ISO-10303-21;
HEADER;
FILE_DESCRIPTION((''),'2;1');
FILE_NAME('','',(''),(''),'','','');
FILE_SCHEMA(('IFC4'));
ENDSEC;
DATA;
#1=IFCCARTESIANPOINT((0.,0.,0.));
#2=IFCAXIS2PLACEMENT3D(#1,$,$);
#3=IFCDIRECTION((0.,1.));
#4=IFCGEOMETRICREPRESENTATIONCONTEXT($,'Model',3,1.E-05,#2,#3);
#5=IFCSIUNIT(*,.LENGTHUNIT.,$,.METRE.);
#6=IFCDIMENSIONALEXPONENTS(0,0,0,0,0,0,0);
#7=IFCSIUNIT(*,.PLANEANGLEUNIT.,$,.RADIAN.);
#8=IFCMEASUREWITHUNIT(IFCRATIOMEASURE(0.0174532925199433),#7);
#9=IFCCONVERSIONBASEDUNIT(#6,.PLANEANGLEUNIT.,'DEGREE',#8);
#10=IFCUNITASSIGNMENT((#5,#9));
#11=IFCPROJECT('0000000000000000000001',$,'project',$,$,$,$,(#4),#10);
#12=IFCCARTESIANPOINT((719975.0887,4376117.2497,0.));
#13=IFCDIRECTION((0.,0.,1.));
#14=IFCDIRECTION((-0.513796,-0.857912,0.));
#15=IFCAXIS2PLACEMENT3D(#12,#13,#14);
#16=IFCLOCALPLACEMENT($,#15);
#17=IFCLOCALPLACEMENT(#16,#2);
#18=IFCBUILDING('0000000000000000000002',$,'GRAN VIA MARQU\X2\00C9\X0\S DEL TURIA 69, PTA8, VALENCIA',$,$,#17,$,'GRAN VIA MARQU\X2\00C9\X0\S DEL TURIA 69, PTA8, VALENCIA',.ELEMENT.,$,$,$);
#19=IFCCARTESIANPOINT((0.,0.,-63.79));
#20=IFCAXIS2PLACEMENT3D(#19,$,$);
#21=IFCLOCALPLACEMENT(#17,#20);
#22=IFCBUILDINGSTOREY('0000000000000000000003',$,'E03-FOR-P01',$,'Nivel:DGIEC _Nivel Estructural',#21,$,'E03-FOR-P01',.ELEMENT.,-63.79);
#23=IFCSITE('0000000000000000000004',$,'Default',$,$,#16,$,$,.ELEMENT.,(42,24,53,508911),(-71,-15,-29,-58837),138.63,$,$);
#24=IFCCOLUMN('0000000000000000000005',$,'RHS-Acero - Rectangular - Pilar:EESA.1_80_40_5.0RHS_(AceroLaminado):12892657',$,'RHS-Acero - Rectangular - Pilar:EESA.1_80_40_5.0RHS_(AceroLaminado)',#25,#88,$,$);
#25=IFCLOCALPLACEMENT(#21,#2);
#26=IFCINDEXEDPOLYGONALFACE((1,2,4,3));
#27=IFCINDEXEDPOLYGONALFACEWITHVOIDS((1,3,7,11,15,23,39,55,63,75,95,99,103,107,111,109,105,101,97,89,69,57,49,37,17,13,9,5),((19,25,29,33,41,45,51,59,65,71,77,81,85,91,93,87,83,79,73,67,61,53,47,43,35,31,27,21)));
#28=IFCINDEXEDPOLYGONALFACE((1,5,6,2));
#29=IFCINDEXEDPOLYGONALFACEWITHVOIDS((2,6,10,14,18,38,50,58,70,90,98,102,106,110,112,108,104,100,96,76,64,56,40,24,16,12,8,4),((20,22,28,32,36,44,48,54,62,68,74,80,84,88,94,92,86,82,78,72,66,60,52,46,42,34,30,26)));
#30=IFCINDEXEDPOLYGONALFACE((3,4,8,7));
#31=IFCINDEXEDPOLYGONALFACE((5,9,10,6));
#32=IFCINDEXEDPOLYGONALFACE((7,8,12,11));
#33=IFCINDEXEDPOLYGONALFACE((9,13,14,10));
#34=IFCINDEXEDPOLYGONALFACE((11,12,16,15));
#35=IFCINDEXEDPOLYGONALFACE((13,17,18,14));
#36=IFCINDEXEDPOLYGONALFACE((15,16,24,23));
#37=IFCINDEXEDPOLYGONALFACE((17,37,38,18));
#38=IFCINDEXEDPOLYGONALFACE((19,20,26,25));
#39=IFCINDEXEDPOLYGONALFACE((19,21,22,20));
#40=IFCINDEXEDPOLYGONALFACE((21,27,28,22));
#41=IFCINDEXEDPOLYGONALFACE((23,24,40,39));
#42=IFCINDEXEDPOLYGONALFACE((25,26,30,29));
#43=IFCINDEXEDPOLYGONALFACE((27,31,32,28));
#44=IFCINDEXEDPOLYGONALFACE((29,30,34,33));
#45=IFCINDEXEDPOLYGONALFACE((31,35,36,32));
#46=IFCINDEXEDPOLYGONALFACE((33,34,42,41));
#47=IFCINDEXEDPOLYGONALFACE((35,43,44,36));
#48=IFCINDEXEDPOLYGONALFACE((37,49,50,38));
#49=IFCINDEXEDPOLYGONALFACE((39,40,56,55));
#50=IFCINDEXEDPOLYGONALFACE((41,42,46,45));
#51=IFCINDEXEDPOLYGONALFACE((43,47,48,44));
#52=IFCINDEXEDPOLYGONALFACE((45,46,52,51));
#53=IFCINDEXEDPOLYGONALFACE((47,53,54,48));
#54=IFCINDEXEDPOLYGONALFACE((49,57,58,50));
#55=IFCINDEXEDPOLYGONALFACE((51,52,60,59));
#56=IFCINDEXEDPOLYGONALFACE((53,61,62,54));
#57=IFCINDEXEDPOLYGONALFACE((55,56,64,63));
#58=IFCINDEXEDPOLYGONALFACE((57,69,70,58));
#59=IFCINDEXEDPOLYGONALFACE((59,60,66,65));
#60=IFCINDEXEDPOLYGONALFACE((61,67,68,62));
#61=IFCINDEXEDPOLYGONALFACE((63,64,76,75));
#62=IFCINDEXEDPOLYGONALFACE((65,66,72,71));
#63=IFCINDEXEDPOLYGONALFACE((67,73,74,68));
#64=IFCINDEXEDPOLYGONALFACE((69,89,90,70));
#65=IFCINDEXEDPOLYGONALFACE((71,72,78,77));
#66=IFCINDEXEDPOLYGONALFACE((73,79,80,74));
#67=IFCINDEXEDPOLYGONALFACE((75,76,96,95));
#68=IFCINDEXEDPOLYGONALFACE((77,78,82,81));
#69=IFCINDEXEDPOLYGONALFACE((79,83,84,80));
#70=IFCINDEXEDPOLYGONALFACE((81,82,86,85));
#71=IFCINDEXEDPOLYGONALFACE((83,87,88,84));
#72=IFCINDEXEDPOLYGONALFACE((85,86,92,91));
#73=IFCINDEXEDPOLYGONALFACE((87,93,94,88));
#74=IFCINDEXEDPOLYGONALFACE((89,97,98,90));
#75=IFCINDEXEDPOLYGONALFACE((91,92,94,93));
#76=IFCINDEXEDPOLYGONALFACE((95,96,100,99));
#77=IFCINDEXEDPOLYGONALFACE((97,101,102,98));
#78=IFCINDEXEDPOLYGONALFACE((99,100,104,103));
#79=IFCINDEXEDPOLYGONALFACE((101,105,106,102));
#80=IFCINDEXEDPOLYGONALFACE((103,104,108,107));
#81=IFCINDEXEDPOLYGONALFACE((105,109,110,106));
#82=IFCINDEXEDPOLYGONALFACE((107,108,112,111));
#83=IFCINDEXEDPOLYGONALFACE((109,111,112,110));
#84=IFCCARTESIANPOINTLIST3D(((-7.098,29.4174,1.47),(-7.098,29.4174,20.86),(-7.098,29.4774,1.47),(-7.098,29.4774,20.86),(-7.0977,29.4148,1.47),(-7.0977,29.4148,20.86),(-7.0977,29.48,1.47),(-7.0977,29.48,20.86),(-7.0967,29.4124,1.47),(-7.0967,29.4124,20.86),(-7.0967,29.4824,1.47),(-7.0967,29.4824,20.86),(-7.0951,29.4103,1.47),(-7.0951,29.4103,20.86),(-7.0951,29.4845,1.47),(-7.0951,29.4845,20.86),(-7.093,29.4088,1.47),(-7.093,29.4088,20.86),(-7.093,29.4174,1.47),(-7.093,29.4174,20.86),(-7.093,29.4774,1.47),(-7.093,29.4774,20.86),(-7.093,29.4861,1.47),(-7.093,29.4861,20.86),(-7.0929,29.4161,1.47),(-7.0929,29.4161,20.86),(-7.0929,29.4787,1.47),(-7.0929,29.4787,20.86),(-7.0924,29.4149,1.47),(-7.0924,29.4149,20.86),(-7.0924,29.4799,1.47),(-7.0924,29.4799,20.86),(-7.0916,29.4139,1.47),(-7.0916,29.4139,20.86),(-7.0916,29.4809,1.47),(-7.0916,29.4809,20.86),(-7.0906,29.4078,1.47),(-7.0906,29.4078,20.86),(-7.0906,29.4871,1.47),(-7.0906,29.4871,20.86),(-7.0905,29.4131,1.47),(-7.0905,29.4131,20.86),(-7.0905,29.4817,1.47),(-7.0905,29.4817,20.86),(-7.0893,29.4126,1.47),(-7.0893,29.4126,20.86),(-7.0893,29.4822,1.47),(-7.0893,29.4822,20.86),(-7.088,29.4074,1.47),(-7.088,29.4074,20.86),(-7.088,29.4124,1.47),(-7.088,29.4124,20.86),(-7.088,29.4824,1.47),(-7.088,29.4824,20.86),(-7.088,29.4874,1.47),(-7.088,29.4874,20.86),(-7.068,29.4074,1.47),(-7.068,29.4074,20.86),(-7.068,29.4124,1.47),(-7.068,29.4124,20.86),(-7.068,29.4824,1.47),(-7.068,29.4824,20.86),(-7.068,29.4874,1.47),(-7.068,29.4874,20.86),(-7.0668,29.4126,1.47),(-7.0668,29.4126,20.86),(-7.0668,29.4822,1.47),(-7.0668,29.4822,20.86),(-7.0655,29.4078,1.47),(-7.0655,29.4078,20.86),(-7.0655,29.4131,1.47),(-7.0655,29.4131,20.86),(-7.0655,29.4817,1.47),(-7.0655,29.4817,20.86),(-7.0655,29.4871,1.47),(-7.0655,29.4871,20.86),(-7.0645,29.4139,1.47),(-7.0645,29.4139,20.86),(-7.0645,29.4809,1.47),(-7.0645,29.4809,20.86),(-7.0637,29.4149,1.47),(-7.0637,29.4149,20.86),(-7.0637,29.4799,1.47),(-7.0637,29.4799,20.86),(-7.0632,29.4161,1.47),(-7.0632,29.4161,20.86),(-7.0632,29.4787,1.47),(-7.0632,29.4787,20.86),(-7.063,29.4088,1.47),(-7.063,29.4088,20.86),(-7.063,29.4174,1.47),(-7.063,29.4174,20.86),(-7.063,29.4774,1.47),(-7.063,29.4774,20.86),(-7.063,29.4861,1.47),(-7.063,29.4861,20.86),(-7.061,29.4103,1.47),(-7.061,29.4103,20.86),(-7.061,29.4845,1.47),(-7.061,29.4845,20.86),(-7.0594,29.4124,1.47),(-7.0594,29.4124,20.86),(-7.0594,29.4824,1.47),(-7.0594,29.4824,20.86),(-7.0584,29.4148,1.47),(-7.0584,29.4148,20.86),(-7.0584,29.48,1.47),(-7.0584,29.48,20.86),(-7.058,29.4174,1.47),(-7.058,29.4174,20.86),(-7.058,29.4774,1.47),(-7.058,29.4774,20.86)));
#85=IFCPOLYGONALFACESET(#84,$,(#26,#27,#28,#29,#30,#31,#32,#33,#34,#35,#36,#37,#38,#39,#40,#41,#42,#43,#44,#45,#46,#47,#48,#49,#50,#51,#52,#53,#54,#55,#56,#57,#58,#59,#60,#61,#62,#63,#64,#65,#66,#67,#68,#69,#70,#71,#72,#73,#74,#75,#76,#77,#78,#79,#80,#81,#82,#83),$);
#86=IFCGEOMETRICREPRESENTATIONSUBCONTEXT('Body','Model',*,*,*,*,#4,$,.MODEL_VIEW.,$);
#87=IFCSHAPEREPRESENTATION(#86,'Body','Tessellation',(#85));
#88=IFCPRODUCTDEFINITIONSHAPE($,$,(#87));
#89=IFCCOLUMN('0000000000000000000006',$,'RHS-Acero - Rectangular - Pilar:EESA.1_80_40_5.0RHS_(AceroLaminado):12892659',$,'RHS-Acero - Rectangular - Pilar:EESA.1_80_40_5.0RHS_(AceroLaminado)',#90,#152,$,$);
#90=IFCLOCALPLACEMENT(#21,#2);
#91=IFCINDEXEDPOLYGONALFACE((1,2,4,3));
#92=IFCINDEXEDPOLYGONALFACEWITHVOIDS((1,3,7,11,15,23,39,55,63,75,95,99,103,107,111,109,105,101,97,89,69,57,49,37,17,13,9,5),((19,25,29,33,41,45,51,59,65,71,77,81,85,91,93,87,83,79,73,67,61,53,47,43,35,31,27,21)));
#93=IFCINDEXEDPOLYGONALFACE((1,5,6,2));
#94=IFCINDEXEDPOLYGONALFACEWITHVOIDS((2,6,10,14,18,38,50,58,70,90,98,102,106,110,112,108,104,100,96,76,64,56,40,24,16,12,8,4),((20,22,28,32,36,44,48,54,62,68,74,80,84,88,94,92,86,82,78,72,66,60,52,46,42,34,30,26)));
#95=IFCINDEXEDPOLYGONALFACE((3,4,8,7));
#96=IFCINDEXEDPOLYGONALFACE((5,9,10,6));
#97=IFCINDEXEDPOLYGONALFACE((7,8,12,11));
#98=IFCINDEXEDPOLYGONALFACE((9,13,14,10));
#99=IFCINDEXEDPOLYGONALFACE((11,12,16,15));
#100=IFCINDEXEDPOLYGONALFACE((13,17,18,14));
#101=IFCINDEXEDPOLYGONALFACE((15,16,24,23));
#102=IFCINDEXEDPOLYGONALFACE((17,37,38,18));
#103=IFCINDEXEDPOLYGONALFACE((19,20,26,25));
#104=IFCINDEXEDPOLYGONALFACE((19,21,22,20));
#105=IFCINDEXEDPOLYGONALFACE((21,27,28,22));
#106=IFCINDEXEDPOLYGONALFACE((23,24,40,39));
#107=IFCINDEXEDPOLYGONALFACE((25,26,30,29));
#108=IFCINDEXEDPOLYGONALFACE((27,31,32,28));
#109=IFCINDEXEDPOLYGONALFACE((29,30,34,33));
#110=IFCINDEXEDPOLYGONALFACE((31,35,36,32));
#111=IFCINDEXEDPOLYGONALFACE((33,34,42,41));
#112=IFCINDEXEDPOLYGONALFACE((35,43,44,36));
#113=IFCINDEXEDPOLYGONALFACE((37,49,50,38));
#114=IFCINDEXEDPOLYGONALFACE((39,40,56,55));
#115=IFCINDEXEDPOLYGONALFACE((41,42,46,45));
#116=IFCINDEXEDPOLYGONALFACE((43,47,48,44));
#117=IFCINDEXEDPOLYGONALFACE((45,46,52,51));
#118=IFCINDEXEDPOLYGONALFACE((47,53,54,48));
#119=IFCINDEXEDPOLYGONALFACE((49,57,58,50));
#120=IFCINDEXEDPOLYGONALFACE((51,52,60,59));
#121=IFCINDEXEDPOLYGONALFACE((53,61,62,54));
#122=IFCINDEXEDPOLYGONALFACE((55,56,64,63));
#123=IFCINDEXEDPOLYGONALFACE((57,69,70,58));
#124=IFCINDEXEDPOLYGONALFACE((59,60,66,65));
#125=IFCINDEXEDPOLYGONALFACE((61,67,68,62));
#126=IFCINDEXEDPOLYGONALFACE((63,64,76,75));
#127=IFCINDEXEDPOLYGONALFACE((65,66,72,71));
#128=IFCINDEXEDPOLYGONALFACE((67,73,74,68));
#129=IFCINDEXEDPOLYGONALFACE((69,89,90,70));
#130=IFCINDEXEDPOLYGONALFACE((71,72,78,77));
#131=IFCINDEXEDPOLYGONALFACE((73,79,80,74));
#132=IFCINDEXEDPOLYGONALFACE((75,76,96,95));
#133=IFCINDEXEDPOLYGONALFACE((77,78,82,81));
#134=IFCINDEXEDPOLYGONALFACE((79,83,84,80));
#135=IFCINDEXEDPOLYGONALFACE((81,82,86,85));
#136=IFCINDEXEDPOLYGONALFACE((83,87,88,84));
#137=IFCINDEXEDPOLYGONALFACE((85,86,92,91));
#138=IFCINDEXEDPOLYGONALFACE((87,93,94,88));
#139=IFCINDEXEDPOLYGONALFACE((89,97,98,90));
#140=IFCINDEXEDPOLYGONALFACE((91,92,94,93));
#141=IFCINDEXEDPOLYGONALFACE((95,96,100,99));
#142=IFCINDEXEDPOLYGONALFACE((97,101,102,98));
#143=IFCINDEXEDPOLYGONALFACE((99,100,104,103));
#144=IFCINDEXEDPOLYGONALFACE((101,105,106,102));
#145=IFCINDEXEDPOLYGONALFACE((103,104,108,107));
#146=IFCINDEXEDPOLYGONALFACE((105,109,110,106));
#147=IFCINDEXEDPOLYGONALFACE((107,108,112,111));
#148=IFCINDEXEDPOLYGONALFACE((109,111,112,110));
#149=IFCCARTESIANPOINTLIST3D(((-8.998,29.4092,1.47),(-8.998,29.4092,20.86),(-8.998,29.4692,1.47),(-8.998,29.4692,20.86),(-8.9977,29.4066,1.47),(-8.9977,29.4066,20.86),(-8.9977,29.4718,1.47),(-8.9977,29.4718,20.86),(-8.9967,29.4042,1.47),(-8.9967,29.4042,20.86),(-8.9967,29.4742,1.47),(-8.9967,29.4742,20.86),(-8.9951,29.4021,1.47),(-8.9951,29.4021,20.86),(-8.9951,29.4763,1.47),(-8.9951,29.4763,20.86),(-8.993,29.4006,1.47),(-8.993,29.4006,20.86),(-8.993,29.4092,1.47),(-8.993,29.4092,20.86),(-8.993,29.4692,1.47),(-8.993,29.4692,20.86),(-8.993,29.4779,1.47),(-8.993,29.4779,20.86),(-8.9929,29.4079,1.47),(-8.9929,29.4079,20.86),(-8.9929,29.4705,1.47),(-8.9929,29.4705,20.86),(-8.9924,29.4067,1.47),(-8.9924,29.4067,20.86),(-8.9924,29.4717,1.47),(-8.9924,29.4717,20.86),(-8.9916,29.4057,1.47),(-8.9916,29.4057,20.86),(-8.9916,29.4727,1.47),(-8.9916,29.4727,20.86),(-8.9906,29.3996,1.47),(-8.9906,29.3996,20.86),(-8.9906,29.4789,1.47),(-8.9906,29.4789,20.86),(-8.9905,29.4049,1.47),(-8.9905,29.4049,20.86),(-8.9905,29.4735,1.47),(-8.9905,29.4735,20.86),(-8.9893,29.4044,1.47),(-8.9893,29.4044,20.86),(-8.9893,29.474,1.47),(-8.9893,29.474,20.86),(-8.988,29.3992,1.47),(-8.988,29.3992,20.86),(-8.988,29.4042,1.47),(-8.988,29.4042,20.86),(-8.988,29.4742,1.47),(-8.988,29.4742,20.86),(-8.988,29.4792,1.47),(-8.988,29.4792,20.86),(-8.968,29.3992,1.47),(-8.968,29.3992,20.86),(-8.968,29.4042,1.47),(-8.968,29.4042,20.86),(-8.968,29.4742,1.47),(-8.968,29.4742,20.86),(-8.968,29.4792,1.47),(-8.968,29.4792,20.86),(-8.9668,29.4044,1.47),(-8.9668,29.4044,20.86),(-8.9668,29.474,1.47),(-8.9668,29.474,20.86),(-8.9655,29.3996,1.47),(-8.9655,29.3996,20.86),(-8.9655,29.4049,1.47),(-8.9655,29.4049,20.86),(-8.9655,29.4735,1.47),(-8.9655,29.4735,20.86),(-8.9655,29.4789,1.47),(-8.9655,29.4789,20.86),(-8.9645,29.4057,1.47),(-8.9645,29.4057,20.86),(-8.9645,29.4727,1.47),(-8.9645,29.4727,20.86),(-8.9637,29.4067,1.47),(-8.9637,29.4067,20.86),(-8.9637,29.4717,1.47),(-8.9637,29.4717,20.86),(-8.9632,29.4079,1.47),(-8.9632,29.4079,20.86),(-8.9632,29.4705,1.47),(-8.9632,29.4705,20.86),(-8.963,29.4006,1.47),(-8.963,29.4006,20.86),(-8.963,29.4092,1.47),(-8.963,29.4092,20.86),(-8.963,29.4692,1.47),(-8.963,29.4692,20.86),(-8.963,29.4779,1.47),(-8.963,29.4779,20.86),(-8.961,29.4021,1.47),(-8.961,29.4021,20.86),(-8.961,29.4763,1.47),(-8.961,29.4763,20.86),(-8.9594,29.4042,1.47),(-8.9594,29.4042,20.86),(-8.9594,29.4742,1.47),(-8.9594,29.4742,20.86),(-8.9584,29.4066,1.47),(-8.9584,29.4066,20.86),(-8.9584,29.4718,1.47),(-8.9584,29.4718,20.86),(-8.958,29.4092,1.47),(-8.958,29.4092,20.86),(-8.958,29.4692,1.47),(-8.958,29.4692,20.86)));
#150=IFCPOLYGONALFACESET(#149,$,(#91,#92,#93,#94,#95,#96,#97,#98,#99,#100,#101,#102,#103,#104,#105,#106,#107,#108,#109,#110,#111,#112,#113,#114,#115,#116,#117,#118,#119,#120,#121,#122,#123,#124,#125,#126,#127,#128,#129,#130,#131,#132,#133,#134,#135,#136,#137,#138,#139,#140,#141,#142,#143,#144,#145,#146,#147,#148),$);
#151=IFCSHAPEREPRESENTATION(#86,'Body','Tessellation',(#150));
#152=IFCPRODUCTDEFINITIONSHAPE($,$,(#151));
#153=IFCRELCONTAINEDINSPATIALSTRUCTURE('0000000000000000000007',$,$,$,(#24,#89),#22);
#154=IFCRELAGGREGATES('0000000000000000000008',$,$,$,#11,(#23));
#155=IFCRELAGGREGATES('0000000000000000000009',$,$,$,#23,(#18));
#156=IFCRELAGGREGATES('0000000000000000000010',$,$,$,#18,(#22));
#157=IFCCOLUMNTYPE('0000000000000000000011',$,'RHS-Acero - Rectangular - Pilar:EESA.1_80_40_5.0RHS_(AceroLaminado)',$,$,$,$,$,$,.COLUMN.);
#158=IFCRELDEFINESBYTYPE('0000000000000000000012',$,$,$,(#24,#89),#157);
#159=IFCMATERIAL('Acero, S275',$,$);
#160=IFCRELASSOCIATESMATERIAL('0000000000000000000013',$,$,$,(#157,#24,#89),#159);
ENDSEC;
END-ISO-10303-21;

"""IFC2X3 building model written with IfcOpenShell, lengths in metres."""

from ifc_helpers import new_model, entity, si_unit, converted_unit, direction, frame, frame_2d, origin, place, context, subcontext, project, spatial, polyline, circle_curve, parameter, trimmed, segment, composite_curve, outline, extrude, source, transform, mapped, material, type_object, type_shapes, element, save


model = new_model("IFC2X3")

# Units and contexts
model_context = context("Model", 3, precision=1e-05, world=origin(), true_north=direction((0.0, 1.0)))
body_context = subcontext(model_context, "Body", "Model", "MODEL_VIEW")
ifc_project = project(units=[si_unit("LENGTHUNIT", "METRE"), converted_unit("PLANEANGLEUNIT", "DEGREE", entity("IfcRatioMeasure", 0.0174532925199433), si_unit("PLANEANGLEUNIT", "RADIAN"), dimensions=[0, 0, 0, 0, 0, 0, 0])], contexts=[model_context])

# Site, building, storey
site_placement = place(None, frame((719975.0887, 4376117.2497, 0.0), z_axis=(0.0, 0.0, 1.0), x_axis=(-0.513796, -0.857912, 0.0)))
site = spatial("IfcSite", under=ifc_project, at=site_placement, Name="Default", CompositionType="ELEMENT", RefLatitude=(42, 24, 53, 508911), RefLongitude=(-71, -15, -29, -58837), RefElevation=138.63)
building_placement = place(site_placement, origin())
building = spatial("IfcBuilding", under=site, at=building_placement, Name="GRAN VIA MARQUÉS DEL TURIA 69, PTA8, VALENCIA", LongName="GRAN VIA MARQUÉS DEL TURIA 69, PTA8, VALENCIA", CompositionType="ELEMENT")
storey_placement = place(building_placement, frame((0.0, 0.0, -63.79)))
storey = spatial("IfcBuildingStorey", under=building, at=storey_placement, Name="E03-FOR-P01", ObjectType="Nivel:DGIEC _Nivel Estructural", LongName="E03-FOR-P01", CompositionType="ELEMENT", Elevation=-63.79)

# Columns
ifc_material_1 = material(Name="Acero, S275")
column_type_1 = type_object("IfcColumnType", Name="RHS-Acero - Rectangular - Pilar:EESA.1_80_40_5.0RHS_(AceroLaminado)", PredefinedType="COLUMN", material=ifc_material_1)
shared_shape_1 = source(origin(), body_context, "Body", "SweptSolid", [
    extrude(outline(composite_curve([segment(polyline([(-0.01, -0.04), (0.01, -0.04)]), True, "CONTINUOUS"), segment(trimmed(circle_curve(frame_2d((0.01, -0.03), x_axis=(-1.0, 0.0)), 0.01), [parameter(90.0)], [parameter(180.0)], True, "PARAMETER"), True, "CONTINUOUS"), segment(polyline([(0.02, -0.03), (0.02, 0.03)]), True, "CONTINUOUS"), segment(trimmed(circle_curve(frame_2d((0.01, 0.03), x_axis=(-1.0, 0.0)), 0.01), [parameter(180.0)], [parameter(270.0)], True, "PARAMETER"), True, "CONTINUOUS"), segment(polyline([(0.01, 0.04), (-0.01, 0.04)]), True, "CONTINUOUS"), segment(trimmed(circle_curve(frame_2d((-0.01, 0.03), x_axis=(-1.0, 0.0)), 0.01), [parameter(270.0)], [parameter(360.0)], True, "PARAMETER"), True, "CONTINUOUS"), segment(polyline([(-0.02, 0.03), (-0.02, -0.03)]), True, "CONTINUOUS"), segment(trimmed(circle_curve(frame_2d((-0.01, -0.03), x_axis=(-1.0, 0.0)), 0.01), [parameter(360.0)], [parameter(90.0)], True, "PARAMETER"), True, "CONTINUOUS")], self_intersect=False), holes=[composite_curve([segment(trimmed(circle_curve(frame_2d((-0.01, -0.03), x_axis=(-1.0, 0.0)), 0.005), [parameter(0.0)], [parameter(90.0)], True, "PARAMETER"), False, "CONTINUOUS"), segment(polyline([(-0.015, -0.03), (-0.015, 0.03)]), True, "CONTINUOUS"), segment(trimmed(circle_curve(frame_2d((-0.01, 0.03), x_axis=(-1.0, 0.0)), 0.005), [parameter(270.0)], [parameter(0.0)], True, "PARAMETER"), False, "CONTINUOUS"), segment(polyline([(-0.01, 0.035), (0.01, 0.035)]), True, "CONTINUOUS"), segment(trimmed(circle_curve(frame_2d((0.01, 0.03), x_axis=(-1.0, 0.0)), 0.005), [parameter(180.0)], [parameter(270.0)], True, "PARAMETER"), False, "CONTINUOUS"), segment(polyline([(0.015, 0.03), (0.015, -0.03)]), True, "CONTINUOUS"), segment(trimmed(circle_curve(frame_2d((0.01, -0.03), x_axis=(-1.0, 0.0)), 0.005), [parameter(90.0)], [parameter(180.0)], True, "PARAMETER"), False, "CONTINUOUS"), segment(polyline([(0.01, -0.035), (-0.01, -0.035)]), True, "CONTINUOUS")], self_intersect=False)]), frame((0.0, 0.0, -62.32), z_axis=(0.0, 0.0, 1.0), x_axis=(-1.0, 0.0, 0.0)), (0.0, 0.0, 1.0), 19.39),
])
type_shapes(column_type_1, [shared_shape_1])
for number, where, z_axis, x_axis, name in (
    (1, (-7.078, 29.4474, 63.79), (0.0, 0.0, 1.0), (-1.0, 0.0, 0.0), "RHS-Acero - Rectangular - Pilar:EESA.1_80_40_5.0RHS_(AceroLaminado):12892657"),
    (2, (-8.978, 29.4392, 63.79), (0.0, 0.0, 1.0), (-1.0, 0.0, 0.0), "RHS-Acero - Rectangular - Pilar:EESA.1_80_40_5.0RHS_(AceroLaminado):12892659"),
):
    element("IfcColumn", number, at=place(storey_placement, frame(where, z_axis=z_axis, x_axis=x_axis)), inside=storey, type_object=column_type_1, material=ifc_material_1, Name=name, ObjectType="RHS-Acero - Rectangular - Pilar:EESA.1_80_40_5.0RHS_(AceroLaminado)", context=body_context, shape_type="MappedRepresentation", body=[
        mapped(shared_shape_1, transform((0.0, 0.0, 0.0), scale=1.0)),
    ])

save(model, "model.ifc")
